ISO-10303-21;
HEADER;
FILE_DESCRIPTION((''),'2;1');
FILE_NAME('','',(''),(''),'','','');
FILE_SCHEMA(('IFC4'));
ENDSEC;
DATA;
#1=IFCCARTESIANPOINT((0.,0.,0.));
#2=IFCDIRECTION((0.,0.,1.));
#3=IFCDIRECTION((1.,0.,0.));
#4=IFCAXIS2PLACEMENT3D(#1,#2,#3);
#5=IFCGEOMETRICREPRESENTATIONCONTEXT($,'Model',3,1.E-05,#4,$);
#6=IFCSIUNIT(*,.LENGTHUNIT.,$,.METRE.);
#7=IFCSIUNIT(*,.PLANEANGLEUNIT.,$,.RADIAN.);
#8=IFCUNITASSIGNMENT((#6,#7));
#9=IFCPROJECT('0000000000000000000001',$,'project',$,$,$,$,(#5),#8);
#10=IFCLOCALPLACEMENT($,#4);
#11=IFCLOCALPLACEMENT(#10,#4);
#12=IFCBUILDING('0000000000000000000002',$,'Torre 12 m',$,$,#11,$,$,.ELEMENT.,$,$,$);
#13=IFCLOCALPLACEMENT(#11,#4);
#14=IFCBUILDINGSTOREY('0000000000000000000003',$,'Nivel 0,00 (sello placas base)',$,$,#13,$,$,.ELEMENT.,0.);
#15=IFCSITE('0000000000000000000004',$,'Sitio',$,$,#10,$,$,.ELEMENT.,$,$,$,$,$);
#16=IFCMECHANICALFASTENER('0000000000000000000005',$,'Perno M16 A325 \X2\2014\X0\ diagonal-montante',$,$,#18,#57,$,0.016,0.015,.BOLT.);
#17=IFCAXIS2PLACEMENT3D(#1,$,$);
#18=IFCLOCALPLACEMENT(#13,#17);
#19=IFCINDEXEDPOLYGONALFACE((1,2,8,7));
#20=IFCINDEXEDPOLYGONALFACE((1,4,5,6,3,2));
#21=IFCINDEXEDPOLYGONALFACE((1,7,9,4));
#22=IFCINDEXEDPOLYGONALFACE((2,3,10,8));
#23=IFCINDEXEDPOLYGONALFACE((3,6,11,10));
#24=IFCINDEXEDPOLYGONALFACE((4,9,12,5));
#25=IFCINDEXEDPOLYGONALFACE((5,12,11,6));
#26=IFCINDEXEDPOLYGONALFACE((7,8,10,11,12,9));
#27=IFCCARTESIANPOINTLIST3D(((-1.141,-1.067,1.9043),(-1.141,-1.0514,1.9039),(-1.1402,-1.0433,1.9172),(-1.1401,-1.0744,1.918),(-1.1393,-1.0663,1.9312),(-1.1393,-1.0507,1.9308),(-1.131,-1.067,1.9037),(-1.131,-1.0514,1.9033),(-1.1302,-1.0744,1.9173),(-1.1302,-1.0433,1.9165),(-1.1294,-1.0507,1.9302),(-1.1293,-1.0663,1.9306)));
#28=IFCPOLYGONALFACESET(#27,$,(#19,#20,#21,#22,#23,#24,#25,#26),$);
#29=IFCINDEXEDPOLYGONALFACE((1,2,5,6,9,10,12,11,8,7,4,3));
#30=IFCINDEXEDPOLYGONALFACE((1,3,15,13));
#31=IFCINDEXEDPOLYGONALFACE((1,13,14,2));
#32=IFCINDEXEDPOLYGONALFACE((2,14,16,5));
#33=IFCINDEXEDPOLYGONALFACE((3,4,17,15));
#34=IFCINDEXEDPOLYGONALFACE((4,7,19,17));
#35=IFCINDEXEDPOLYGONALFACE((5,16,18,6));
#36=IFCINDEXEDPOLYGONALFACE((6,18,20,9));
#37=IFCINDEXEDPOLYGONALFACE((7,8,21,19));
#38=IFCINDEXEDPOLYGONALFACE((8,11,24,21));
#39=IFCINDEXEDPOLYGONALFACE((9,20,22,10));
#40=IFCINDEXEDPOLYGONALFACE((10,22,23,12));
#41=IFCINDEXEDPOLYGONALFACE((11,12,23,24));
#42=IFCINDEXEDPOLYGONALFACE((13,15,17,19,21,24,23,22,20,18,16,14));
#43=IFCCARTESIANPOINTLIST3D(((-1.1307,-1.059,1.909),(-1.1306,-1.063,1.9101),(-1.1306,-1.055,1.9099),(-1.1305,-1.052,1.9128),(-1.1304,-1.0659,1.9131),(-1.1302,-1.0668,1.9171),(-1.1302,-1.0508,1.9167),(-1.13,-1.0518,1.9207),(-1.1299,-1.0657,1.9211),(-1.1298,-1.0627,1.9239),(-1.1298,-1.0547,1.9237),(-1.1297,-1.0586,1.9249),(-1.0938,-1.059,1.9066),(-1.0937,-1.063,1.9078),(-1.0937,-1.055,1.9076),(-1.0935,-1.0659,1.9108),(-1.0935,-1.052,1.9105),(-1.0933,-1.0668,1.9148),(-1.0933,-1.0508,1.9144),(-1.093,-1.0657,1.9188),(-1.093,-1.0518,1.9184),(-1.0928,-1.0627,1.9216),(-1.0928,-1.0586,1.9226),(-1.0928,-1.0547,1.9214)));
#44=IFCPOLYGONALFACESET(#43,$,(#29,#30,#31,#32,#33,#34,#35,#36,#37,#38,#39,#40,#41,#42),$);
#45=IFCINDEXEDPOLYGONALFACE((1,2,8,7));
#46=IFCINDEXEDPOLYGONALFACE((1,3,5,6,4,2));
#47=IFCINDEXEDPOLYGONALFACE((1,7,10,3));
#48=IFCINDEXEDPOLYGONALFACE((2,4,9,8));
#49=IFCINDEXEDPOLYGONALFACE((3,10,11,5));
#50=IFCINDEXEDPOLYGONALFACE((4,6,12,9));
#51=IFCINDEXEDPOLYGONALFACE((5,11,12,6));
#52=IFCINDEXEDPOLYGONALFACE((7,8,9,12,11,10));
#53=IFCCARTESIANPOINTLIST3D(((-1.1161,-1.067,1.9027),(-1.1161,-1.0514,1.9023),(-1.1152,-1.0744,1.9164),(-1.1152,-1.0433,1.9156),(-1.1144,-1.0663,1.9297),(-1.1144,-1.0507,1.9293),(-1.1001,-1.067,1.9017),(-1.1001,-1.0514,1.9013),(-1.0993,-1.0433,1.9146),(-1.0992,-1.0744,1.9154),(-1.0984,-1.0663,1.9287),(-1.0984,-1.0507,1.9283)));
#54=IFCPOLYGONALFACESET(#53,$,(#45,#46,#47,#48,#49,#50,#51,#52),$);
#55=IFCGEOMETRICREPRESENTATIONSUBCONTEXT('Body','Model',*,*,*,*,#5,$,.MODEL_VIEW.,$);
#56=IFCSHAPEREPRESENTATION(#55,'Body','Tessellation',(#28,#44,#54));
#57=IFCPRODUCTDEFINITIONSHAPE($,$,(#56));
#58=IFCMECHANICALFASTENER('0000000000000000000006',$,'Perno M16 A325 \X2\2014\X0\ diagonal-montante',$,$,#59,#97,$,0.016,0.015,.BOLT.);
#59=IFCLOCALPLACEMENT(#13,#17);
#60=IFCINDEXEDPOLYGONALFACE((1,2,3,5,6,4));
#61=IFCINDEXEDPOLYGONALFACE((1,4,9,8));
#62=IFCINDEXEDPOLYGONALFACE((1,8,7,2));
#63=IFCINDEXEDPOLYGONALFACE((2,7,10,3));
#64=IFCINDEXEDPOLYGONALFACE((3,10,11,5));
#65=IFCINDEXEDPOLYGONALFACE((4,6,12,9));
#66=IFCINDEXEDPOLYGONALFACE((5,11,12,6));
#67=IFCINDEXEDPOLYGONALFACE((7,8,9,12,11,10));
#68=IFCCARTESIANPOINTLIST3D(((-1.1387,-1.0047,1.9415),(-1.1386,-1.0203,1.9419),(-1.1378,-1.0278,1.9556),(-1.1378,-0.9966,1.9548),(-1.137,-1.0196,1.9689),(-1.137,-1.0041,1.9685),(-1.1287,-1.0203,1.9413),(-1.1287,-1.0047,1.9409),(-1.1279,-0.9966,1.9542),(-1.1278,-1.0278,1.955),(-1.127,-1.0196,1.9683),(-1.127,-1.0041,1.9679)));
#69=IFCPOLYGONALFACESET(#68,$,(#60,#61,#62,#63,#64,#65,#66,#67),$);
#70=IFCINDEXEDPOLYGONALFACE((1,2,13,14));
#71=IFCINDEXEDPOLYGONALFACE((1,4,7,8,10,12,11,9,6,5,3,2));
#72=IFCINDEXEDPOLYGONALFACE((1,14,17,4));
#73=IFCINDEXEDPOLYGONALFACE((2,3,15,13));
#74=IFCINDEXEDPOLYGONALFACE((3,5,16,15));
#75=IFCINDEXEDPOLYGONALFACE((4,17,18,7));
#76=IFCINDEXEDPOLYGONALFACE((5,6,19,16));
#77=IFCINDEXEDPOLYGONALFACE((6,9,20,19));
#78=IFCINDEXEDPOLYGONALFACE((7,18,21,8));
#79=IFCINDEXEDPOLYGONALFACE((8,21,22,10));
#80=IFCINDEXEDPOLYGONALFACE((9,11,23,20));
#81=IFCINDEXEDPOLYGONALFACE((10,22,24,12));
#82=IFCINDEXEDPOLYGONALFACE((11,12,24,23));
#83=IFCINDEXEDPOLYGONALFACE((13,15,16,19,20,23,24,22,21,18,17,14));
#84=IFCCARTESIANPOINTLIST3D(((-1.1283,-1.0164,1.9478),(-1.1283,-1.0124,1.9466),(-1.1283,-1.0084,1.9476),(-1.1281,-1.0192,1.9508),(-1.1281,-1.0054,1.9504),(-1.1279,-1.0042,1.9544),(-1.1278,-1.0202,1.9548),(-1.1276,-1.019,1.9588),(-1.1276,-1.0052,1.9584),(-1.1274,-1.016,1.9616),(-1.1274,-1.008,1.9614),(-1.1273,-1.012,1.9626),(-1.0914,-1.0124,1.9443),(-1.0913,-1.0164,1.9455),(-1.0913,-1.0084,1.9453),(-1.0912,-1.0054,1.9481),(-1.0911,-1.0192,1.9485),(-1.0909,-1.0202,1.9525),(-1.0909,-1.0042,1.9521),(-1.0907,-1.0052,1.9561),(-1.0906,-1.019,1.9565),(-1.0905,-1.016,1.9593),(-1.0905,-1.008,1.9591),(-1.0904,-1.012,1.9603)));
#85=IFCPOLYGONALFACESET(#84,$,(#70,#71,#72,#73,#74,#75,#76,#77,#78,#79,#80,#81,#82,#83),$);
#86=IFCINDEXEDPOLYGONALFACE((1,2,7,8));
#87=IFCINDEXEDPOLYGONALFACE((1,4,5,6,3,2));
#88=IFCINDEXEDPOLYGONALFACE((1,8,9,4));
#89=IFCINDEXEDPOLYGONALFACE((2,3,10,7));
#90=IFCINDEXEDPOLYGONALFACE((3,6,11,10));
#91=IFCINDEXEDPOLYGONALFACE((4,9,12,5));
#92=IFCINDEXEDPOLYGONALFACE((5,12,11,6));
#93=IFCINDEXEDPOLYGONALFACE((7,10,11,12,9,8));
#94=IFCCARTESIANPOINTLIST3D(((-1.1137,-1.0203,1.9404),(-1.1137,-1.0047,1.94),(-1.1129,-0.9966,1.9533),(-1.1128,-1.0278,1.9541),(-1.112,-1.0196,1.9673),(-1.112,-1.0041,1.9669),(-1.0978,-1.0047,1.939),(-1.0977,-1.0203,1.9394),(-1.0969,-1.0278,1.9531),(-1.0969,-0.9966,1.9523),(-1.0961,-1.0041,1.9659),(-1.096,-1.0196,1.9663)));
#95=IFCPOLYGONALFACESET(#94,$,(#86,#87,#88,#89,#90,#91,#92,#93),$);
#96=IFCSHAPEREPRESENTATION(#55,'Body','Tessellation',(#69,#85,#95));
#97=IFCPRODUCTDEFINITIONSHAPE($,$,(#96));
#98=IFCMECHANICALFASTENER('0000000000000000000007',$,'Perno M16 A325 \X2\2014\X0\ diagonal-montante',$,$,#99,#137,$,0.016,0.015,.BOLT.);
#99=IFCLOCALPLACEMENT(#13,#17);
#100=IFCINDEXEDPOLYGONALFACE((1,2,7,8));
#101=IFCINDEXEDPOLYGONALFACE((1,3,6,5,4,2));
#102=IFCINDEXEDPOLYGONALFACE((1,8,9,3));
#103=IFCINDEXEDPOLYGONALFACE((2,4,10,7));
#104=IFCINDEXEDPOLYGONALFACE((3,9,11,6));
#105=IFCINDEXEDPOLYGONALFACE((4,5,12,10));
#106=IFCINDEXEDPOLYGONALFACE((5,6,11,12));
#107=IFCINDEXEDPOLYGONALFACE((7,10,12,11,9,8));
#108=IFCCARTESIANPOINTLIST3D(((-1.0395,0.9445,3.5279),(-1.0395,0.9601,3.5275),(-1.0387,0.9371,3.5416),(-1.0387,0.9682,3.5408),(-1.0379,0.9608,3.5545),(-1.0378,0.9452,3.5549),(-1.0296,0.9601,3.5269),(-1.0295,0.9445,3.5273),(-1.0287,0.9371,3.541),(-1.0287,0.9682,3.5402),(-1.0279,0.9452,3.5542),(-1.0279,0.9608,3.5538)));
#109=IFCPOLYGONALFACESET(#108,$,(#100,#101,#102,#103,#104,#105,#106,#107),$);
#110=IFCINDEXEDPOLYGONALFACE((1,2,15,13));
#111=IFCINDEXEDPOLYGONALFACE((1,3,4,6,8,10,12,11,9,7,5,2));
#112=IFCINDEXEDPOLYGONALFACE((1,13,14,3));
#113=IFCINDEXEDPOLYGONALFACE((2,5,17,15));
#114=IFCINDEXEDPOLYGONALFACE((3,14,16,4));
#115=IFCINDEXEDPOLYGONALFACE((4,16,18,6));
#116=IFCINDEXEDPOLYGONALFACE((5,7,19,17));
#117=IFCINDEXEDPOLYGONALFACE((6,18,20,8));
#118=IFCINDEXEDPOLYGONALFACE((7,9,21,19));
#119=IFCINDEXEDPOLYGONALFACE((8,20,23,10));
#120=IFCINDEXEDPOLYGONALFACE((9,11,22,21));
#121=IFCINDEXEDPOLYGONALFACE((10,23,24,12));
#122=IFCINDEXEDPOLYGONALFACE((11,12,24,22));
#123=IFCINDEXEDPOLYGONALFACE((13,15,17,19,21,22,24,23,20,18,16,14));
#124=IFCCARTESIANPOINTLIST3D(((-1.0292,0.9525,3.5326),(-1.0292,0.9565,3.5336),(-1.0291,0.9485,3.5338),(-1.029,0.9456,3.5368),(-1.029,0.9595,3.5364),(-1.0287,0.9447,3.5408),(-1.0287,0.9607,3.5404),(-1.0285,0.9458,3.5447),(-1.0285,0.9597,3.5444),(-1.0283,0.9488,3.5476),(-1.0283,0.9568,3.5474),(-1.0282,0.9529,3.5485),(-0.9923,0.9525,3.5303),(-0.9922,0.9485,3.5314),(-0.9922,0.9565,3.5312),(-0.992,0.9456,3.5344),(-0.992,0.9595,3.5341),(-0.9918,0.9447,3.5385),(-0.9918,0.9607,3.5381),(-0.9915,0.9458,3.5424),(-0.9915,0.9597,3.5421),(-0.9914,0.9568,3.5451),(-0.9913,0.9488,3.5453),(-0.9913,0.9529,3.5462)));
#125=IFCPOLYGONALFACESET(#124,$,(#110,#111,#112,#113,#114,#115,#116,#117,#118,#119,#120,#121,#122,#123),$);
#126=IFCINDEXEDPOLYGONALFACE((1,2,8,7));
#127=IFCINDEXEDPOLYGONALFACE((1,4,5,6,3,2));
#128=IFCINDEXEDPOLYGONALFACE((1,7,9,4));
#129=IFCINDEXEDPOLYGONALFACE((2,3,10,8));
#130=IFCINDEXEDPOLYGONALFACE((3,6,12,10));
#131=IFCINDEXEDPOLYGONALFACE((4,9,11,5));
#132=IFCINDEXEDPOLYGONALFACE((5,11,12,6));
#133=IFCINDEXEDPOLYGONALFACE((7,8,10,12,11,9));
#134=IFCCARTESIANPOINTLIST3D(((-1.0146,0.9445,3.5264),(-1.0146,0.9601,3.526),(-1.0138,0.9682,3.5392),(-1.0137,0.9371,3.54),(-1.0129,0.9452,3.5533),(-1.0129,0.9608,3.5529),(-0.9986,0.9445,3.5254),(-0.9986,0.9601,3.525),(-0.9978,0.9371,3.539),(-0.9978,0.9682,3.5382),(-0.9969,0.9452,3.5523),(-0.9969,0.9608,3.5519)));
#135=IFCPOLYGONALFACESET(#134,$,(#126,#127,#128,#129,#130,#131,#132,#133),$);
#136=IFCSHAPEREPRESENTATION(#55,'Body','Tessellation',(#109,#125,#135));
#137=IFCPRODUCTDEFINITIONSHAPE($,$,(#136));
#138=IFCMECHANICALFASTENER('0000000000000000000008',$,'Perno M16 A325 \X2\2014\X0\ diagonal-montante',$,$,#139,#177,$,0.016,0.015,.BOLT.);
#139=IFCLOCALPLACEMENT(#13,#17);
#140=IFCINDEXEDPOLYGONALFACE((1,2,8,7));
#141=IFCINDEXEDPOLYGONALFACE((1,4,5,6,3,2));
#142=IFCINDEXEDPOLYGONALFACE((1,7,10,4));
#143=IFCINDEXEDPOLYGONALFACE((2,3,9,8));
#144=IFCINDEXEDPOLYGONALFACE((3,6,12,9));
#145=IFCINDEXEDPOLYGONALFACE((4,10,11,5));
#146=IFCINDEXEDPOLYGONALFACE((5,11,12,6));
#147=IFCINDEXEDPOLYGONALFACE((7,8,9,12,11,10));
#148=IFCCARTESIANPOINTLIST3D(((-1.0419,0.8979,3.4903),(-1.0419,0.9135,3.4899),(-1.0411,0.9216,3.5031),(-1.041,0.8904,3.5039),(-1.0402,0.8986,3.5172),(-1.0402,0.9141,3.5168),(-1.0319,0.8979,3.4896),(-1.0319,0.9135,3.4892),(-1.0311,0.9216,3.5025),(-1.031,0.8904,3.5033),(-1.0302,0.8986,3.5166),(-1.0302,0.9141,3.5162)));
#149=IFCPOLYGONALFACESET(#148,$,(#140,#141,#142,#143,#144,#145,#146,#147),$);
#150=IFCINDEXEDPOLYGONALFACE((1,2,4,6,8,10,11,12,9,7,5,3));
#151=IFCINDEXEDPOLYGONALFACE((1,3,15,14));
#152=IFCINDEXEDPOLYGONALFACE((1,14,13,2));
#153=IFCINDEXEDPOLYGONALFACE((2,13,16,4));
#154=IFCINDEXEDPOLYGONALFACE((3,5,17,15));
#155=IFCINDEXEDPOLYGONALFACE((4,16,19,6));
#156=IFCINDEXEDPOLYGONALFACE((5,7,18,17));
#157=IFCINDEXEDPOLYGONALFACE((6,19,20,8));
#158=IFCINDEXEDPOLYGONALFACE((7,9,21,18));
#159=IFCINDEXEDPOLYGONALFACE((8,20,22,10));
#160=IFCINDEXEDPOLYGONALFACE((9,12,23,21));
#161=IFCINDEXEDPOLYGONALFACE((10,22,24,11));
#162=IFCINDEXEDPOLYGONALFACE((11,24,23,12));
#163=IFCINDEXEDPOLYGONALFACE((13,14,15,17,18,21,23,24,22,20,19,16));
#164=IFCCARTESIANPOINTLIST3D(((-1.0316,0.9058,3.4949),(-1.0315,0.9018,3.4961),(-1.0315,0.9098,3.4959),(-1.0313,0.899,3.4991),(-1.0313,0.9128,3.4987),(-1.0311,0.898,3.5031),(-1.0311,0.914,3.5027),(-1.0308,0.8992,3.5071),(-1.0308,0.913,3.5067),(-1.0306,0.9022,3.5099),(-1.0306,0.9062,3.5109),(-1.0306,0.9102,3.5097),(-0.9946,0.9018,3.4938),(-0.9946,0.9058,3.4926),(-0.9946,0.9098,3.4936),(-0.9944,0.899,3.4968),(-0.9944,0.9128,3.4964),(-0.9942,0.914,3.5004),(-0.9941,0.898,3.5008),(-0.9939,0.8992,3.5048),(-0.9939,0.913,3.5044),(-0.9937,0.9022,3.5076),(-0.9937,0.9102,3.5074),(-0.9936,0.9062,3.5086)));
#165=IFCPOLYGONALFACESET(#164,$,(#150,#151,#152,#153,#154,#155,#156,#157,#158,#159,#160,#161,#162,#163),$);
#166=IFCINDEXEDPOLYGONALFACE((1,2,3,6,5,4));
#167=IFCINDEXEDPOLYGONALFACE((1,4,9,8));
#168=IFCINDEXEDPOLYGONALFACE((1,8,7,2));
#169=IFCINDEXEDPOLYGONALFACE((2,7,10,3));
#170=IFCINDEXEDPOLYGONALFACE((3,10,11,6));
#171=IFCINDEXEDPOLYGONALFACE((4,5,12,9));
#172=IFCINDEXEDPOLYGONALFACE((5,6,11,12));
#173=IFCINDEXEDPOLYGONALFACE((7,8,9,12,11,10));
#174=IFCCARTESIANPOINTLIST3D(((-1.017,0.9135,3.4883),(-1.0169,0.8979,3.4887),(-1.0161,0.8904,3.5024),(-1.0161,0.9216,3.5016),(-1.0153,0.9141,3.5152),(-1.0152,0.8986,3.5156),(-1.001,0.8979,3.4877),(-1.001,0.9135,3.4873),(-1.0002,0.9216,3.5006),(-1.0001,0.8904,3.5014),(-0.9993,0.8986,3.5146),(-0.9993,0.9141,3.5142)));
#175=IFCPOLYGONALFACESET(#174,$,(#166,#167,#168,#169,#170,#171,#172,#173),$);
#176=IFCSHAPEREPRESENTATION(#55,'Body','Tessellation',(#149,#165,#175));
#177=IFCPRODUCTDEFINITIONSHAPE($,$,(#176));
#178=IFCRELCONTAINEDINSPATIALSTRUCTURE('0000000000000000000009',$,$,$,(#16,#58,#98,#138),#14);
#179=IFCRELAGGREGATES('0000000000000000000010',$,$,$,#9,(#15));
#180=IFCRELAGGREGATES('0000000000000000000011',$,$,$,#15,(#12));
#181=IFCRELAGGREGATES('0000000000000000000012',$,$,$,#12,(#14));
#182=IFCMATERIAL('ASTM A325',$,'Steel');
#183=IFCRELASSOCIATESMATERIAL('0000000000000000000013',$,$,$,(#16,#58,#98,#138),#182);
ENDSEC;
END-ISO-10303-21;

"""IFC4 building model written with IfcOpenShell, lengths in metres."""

from ifc_helpers import new_model, si_unit, frame, origin_with_axes, place, context, subcontext, project, spatial, polyline, outline, extrude, material, element, save


model = new_model("IFC4")

# Units and contexts
model_context = context("Model", 3, precision=1e-05, world=origin_with_axes())
body_context = subcontext(model_context, "Body", "Model", "MODEL_VIEW")
ifc_project = project(units=[si_unit("LENGTHUNIT", "METRE"), si_unit("PLANEANGLEUNIT", "RADIAN")], contexts=[model_context])

# Site, building, storey
site_placement = place(None, origin_with_axes())
site = spatial("IfcSite", under=ifc_project, at=site_placement, Name="Sitio", CompositionType="ELEMENT")
building_placement = place(site_placement, origin_with_axes())
building = spatial("IfcBuilding", under=site, at=building_placement, Name="Torre 12 m", CompositionType="ELEMENT")
storey_placement = place(building_placement, origin_with_axes())
storey = spatial("IfcBuildingStorey", under=building, at=storey_placement, Name="Nivel 0,00 (sello placas base)", CompositionType="ELEMENT", Elevation=0.0)

# Shared definitions
placement = place(storey_placement, origin_with_axes())

# Mechanical fasteners
ifc_material_1 = material(Name="ASTM A325", Category="Steel")
element("IfcMechanicalFastener", 1, at=placement, inside=storey, material=ifc_material_1, Name="Perno M16 A325 — diagonal-montante", NominalDiameter=0.016, NominalLength=0.015, PredefinedType="BOLT", context=body_context, shape_type="SweptSolid", body=[
    extrude(outline(polyline([(0.0135, 0.0078), (0.0, 0.0156), (-0.0135, 0.0078), (-0.0135, -0.0078), (0.0, -0.0156), (0.0135, -0.0078), (0.0135, 0.0078)])), frame((-1.1402, -1.0588, 1.9176), z_axis=(0.998053, 0.0, -0.062378), x_axis=(0.032557, -0.85299, 0.52091)), (0.0, 0.0, 1.0), 0.01),
    extrude(outline(polyline([(0.008, 0.0), (0.0069, 0.004), (0.004, 0.0069), (0.0, 0.008), (-0.004, 0.0069), (-0.0069, 0.004), (-0.008, 0.0), (-0.0069, -0.004), (-0.004, -0.0069), (0.0, -0.008), (0.004, -0.0069), (0.0069, -0.004), (0.008, 0.0)])), frame((-1.1302, -1.0588, 1.9169), z_axis=(0.998053, 0.0, -0.062378), x_axis=(0.032557, -0.85299, 0.52091)), (0.0, 0.0, 1.0), 0.037),
    extrude(outline(polyline([(0.0135, 0.0078), (0.0, 0.0156), (-0.0135, 0.0078), (-0.0135, -0.0078), (0.0, -0.0156), (0.0135, -0.0078), (0.0135, 0.0078)])), frame((-1.1152, -1.0588, 1.916), z_axis=(0.998053, 0.0, -0.062378), x_axis=(0.032557, -0.85299, 0.52091)), (0.0, 0.0, 1.0), 0.016),
])
element("IfcMechanicalFastener", 2, at=placement, inside=storey, material=ifc_material_1, Name="Perno M16 A325 — diagonal-montante", NominalDiameter=0.016, NominalLength=0.015, PredefinedType="BOLT", context=body_context, shape_type="SweptSolid", body=[
    extrude(outline(polyline([(0.0135, 0.0078), (0.0, 0.0156), (-0.0135, 0.0078), (-0.0135, -0.0078), (0.0, -0.0156), (0.0135, -0.0078), (0.0135, 0.0078)])), frame((-1.1378, -1.0122, 1.9552), z_axis=(0.998053, 0.0, -0.062378), x_axis=(0.032557, -0.85299, 0.52091)), (0.0, 0.0, 1.0), 0.01),
    extrude(outline(polyline([(0.008, 0.0), (0.0069, 0.004), (0.004, 0.0069), (0.0, 0.008), (-0.004, 0.0069), (-0.0069, 0.004), (-0.008, 0.0), (-0.0069, -0.004), (-0.004, -0.0069), (0.0, -0.008), (0.004, -0.0069), (0.0069, -0.004), (0.008, 0.0)])), frame((-1.1278, -1.0122, 1.9546), z_axis=(0.998053, 0.0, -0.062378), x_axis=(0.032557, -0.85299, 0.52091)), (0.0, 0.0, 1.0), 0.037),
    extrude(outline(polyline([(0.0135, 0.0078), (0.0, 0.0156), (-0.0135, 0.0078), (-0.0135, -0.0078), (0.0, -0.0156), (0.0135, -0.0078), (0.0135, 0.0078)])), frame((-1.1129, -1.0122, 1.9537), z_axis=(0.998053, 0.0, -0.062378), x_axis=(0.032557, -0.85299, 0.52091)), (0.0, 0.0, 1.0), 0.016),
])
element("IfcMechanicalFastener", 3, at=placement, inside=storey, material=ifc_material_1, Name="Perno M16 A325 — diagonal-montante", NominalDiameter=0.016, NominalLength=0.015, PredefinedType="BOLT", context=body_context, shape_type="SweptSolid", body=[
    extrude(outline(polyline([(0.0135, 0.0078), (0.0, 0.0156), (-0.0135, 0.0078), (-0.0135, -0.0078), (0.0, -0.0156), (0.0135, -0.0078), (0.0135, 0.0078)])), frame((-1.0387, 0.9527, 3.5412), z_axis=(0.998053, 0.0, -0.062378), x_axis=(0.032557, -0.85299, 0.52091)), (0.0, 0.0, 1.0), 0.01),
    extrude(outline(polyline([(0.008, 0.0), (0.0069, 0.004), (0.004, 0.0069), (0.0, 0.008), (-0.004, 0.0069), (-0.0069, 0.004), (-0.008, 0.0), (-0.0069, -0.004), (-0.004, -0.0069), (0.0, -0.008), (0.004, -0.0069), (0.0069, -0.004), (0.008, 0.0)])), frame((-1.0287, 0.9527, 3.5406), z_axis=(0.998053, 0.0, -0.062378), x_axis=(0.032557, -0.85299, 0.52091)), (0.0, 0.0, 1.0), 0.037),
    extrude(outline(polyline([(0.0135, 0.0078), (0.0, 0.0156), (-0.0135, 0.0078), (-0.0135, -0.0078), (0.0, -0.0156), (0.0135, -0.0078), (0.0135, 0.0078)])), frame((-1.0137, 0.9527, 3.5396), z_axis=(0.998053, 0.0, -0.062378), x_axis=(0.032557, -0.85299, 0.52091)), (0.0, 0.0, 1.0), 0.016),
])
element("IfcMechanicalFastener", 4, at=placement, inside=storey, material=ifc_material_1, Name="Perno M16 A325 — diagonal-montante", NominalDiameter=0.016, NominalLength=0.015, PredefinedType="BOLT", context=body_context, shape_type="SweptSolid", body=[
    extrude(outline(polyline([(0.0135, 0.0078), (0.0, 0.0156), (-0.0135, 0.0078), (-0.0135, -0.0078), (0.0, -0.0156), (0.0135, -0.0078), (0.0135, 0.0078)])), frame((-1.041, 0.906, 3.5035), z_axis=(0.998053, 0.0, -0.062378), x_axis=(0.032557, -0.85299, 0.52091)), (0.0, 0.0, 1.0), 0.01),
    extrude(outline(polyline([(0.008, 0.0), (0.0069, 0.004), (0.004, 0.0069), (0.0, 0.008), (-0.004, 0.0069), (-0.0069, 0.004), (-0.008, 0.0), (-0.0069, -0.004), (-0.004, -0.0069), (0.0, -0.008), (0.004, -0.0069), (0.0069, -0.004), (0.008, 0.0)])), frame((-1.0311, 0.906, 3.5029), z_axis=(0.998053, 0.0, -0.062378), x_axis=(0.032557, -0.85299, 0.52091)), (0.0, 0.0, 1.0), 0.037),
    extrude(outline(polyline([(0.0135, 0.0078), (0.0, 0.0156), (-0.0135, 0.0078), (-0.0135, -0.0078), (0.0, -0.0156), (0.0135, -0.0078), (0.0135, 0.0078)])), frame((-1.0161, 0.906, 3.502), z_axis=(0.998053, 0.0, -0.062378), x_axis=(0.032557, -0.85299, 0.52091)), (0.0, 0.0, 1.0), 0.016),
])

save(model, "model.ifc")
